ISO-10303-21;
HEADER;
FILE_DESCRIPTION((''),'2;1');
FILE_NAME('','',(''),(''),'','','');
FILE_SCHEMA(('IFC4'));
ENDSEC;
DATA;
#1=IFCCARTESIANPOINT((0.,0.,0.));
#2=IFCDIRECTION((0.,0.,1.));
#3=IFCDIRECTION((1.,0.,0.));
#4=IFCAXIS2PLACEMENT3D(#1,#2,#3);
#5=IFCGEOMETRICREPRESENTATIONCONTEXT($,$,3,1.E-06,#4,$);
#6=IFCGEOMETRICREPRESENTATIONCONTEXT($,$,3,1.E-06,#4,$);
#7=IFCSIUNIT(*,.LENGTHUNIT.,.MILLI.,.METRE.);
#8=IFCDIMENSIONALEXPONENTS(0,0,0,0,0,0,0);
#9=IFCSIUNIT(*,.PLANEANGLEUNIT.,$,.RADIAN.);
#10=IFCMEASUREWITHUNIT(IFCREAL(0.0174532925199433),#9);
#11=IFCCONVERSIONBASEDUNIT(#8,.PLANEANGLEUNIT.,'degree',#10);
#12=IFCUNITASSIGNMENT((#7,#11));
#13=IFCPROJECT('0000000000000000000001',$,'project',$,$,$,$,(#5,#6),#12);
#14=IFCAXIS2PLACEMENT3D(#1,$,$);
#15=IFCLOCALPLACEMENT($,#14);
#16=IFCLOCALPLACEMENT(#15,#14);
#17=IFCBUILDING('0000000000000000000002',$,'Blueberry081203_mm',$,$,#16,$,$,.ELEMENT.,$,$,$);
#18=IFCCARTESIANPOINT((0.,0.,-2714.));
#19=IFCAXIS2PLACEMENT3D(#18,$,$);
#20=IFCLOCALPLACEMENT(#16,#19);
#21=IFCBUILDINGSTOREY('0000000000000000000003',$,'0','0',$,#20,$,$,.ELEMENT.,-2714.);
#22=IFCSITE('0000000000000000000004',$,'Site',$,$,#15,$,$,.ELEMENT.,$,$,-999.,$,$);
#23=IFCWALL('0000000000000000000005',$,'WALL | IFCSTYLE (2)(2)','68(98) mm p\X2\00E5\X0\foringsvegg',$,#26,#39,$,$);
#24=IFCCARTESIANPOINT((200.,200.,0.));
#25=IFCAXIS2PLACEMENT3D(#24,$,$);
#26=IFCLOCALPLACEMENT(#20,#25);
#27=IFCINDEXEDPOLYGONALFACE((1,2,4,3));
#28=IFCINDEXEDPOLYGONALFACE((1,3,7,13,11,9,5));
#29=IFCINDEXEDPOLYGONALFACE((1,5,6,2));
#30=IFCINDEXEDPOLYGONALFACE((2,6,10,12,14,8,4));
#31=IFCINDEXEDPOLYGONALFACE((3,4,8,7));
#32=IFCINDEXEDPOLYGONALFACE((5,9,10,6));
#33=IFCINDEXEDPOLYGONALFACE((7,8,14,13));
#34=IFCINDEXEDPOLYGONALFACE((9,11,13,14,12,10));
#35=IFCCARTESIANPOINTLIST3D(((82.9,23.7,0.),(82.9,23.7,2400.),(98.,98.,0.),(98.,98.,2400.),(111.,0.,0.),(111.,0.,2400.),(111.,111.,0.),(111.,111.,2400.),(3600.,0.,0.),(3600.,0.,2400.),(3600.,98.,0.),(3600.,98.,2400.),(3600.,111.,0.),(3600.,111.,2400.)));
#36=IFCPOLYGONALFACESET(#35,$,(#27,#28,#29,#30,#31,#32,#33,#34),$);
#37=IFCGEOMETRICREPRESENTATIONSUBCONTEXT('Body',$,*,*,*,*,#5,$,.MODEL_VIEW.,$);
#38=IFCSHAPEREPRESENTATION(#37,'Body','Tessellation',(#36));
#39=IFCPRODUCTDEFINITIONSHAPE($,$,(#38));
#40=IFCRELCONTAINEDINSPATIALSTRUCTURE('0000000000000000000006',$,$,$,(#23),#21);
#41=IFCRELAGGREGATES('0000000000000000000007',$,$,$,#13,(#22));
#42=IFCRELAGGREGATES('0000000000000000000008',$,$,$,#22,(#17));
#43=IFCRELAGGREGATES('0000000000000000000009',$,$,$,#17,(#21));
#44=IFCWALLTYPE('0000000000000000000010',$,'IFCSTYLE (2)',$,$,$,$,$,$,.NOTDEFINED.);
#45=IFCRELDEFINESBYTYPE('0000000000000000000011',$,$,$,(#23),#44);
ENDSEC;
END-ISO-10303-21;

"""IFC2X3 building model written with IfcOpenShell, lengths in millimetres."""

from ifc_helpers import new_model, entity, si_unit, converted_unit, frame, origin, origin_with_axes, place, context, subcontext, project, spatial, polyline, segment, composite_curve, outline, extrude, type_object, element, save


model = new_model("IFC2X3")

# Units and contexts
context_of_model_1 = context(None, 3, precision=1e-06, world=origin_with_axes())
context_of_model_2 = context(None, 3, precision=1e-06, world=origin_with_axes())
body_context = subcontext(context_of_model_1, "Body", None, "MODEL_VIEW")
ifc_project = project(units=[si_unit("LENGTHUNIT", "METRE", prefix="MILLI"), converted_unit("PLANEANGLEUNIT", "degree", entity("IfcReal", 0.0174532925199433), si_unit("PLANEANGLEUNIT", "RADIAN"), dimensions=[0, 0, 0, 0, 0, 0, 0])], contexts=[context_of_model_1, context_of_model_2])

# Site, building, storey
site_placement = place(None, origin())
site = spatial("IfcSite", under=ifc_project, at=site_placement, Name="Site", CompositionType="ELEMENT", RefElevation=-999.0)
building_placement = place(site_placement, origin())
building = spatial("IfcBuilding", under=site, at=building_placement, Name="Blueberry081203_mm", CompositionType="ELEMENT")
storey_placement = place(building_placement, frame((0.0, 0.0, -2714.0)))
storey = spatial("IfcBuildingStorey", under=building, at=storey_placement, Name="0", Description="0", CompositionType="ELEMENT", Elevation=-2714.0)

# Wall
wall_type_1 = type_object("IfcWallType", Name="IFCSTYLE (2)", PredefinedType="NOTDEFINED")
wall_1_placement = place(storey_placement, frame((200.0, 200.0, 0.0)))
element("IfcWall", 1, at=wall_1_placement, inside=storey, type_object=wall_type_1, Name="WALL | IFCSTYLE (2)(2)", Description="68(98) mm påforingsvegg", context=body_context, shape_type="SweptSolid", held_by="IfcProductRepresentation", body=[
    extrude(outline(composite_curve([segment(polyline([(98.0, 98.0), (82.9, 23.7)]), True, "CONTINUOUS"), segment(polyline([(82.9, 23.7), (111.0, 0.0)]), True, "CONTINUOUS"), segment(polyline([(111.0, 0.0), (3600.0, 0.0)]), True, "CONTINUOUS"), segment(polyline([(3600.0, 0.0), (3600.0, 98.0)]), True, "CONTINUOUS"), segment(polyline([(3600.0, 98.0), (3600.0, 111.0)]), True, "CONTINUOUS"), segment(polyline([(3600.0, 111.0), (111.0, 111.0)]), True, "CONTINUOUS"), segment(polyline([(111.0, 111.0), (98.0, 98.0)]), True, "CONTINUOUS")], self_intersect=False)), origin(), (0.0, 0.0, 1.0), 2400.0),
])

save(model, "model.ifc")
